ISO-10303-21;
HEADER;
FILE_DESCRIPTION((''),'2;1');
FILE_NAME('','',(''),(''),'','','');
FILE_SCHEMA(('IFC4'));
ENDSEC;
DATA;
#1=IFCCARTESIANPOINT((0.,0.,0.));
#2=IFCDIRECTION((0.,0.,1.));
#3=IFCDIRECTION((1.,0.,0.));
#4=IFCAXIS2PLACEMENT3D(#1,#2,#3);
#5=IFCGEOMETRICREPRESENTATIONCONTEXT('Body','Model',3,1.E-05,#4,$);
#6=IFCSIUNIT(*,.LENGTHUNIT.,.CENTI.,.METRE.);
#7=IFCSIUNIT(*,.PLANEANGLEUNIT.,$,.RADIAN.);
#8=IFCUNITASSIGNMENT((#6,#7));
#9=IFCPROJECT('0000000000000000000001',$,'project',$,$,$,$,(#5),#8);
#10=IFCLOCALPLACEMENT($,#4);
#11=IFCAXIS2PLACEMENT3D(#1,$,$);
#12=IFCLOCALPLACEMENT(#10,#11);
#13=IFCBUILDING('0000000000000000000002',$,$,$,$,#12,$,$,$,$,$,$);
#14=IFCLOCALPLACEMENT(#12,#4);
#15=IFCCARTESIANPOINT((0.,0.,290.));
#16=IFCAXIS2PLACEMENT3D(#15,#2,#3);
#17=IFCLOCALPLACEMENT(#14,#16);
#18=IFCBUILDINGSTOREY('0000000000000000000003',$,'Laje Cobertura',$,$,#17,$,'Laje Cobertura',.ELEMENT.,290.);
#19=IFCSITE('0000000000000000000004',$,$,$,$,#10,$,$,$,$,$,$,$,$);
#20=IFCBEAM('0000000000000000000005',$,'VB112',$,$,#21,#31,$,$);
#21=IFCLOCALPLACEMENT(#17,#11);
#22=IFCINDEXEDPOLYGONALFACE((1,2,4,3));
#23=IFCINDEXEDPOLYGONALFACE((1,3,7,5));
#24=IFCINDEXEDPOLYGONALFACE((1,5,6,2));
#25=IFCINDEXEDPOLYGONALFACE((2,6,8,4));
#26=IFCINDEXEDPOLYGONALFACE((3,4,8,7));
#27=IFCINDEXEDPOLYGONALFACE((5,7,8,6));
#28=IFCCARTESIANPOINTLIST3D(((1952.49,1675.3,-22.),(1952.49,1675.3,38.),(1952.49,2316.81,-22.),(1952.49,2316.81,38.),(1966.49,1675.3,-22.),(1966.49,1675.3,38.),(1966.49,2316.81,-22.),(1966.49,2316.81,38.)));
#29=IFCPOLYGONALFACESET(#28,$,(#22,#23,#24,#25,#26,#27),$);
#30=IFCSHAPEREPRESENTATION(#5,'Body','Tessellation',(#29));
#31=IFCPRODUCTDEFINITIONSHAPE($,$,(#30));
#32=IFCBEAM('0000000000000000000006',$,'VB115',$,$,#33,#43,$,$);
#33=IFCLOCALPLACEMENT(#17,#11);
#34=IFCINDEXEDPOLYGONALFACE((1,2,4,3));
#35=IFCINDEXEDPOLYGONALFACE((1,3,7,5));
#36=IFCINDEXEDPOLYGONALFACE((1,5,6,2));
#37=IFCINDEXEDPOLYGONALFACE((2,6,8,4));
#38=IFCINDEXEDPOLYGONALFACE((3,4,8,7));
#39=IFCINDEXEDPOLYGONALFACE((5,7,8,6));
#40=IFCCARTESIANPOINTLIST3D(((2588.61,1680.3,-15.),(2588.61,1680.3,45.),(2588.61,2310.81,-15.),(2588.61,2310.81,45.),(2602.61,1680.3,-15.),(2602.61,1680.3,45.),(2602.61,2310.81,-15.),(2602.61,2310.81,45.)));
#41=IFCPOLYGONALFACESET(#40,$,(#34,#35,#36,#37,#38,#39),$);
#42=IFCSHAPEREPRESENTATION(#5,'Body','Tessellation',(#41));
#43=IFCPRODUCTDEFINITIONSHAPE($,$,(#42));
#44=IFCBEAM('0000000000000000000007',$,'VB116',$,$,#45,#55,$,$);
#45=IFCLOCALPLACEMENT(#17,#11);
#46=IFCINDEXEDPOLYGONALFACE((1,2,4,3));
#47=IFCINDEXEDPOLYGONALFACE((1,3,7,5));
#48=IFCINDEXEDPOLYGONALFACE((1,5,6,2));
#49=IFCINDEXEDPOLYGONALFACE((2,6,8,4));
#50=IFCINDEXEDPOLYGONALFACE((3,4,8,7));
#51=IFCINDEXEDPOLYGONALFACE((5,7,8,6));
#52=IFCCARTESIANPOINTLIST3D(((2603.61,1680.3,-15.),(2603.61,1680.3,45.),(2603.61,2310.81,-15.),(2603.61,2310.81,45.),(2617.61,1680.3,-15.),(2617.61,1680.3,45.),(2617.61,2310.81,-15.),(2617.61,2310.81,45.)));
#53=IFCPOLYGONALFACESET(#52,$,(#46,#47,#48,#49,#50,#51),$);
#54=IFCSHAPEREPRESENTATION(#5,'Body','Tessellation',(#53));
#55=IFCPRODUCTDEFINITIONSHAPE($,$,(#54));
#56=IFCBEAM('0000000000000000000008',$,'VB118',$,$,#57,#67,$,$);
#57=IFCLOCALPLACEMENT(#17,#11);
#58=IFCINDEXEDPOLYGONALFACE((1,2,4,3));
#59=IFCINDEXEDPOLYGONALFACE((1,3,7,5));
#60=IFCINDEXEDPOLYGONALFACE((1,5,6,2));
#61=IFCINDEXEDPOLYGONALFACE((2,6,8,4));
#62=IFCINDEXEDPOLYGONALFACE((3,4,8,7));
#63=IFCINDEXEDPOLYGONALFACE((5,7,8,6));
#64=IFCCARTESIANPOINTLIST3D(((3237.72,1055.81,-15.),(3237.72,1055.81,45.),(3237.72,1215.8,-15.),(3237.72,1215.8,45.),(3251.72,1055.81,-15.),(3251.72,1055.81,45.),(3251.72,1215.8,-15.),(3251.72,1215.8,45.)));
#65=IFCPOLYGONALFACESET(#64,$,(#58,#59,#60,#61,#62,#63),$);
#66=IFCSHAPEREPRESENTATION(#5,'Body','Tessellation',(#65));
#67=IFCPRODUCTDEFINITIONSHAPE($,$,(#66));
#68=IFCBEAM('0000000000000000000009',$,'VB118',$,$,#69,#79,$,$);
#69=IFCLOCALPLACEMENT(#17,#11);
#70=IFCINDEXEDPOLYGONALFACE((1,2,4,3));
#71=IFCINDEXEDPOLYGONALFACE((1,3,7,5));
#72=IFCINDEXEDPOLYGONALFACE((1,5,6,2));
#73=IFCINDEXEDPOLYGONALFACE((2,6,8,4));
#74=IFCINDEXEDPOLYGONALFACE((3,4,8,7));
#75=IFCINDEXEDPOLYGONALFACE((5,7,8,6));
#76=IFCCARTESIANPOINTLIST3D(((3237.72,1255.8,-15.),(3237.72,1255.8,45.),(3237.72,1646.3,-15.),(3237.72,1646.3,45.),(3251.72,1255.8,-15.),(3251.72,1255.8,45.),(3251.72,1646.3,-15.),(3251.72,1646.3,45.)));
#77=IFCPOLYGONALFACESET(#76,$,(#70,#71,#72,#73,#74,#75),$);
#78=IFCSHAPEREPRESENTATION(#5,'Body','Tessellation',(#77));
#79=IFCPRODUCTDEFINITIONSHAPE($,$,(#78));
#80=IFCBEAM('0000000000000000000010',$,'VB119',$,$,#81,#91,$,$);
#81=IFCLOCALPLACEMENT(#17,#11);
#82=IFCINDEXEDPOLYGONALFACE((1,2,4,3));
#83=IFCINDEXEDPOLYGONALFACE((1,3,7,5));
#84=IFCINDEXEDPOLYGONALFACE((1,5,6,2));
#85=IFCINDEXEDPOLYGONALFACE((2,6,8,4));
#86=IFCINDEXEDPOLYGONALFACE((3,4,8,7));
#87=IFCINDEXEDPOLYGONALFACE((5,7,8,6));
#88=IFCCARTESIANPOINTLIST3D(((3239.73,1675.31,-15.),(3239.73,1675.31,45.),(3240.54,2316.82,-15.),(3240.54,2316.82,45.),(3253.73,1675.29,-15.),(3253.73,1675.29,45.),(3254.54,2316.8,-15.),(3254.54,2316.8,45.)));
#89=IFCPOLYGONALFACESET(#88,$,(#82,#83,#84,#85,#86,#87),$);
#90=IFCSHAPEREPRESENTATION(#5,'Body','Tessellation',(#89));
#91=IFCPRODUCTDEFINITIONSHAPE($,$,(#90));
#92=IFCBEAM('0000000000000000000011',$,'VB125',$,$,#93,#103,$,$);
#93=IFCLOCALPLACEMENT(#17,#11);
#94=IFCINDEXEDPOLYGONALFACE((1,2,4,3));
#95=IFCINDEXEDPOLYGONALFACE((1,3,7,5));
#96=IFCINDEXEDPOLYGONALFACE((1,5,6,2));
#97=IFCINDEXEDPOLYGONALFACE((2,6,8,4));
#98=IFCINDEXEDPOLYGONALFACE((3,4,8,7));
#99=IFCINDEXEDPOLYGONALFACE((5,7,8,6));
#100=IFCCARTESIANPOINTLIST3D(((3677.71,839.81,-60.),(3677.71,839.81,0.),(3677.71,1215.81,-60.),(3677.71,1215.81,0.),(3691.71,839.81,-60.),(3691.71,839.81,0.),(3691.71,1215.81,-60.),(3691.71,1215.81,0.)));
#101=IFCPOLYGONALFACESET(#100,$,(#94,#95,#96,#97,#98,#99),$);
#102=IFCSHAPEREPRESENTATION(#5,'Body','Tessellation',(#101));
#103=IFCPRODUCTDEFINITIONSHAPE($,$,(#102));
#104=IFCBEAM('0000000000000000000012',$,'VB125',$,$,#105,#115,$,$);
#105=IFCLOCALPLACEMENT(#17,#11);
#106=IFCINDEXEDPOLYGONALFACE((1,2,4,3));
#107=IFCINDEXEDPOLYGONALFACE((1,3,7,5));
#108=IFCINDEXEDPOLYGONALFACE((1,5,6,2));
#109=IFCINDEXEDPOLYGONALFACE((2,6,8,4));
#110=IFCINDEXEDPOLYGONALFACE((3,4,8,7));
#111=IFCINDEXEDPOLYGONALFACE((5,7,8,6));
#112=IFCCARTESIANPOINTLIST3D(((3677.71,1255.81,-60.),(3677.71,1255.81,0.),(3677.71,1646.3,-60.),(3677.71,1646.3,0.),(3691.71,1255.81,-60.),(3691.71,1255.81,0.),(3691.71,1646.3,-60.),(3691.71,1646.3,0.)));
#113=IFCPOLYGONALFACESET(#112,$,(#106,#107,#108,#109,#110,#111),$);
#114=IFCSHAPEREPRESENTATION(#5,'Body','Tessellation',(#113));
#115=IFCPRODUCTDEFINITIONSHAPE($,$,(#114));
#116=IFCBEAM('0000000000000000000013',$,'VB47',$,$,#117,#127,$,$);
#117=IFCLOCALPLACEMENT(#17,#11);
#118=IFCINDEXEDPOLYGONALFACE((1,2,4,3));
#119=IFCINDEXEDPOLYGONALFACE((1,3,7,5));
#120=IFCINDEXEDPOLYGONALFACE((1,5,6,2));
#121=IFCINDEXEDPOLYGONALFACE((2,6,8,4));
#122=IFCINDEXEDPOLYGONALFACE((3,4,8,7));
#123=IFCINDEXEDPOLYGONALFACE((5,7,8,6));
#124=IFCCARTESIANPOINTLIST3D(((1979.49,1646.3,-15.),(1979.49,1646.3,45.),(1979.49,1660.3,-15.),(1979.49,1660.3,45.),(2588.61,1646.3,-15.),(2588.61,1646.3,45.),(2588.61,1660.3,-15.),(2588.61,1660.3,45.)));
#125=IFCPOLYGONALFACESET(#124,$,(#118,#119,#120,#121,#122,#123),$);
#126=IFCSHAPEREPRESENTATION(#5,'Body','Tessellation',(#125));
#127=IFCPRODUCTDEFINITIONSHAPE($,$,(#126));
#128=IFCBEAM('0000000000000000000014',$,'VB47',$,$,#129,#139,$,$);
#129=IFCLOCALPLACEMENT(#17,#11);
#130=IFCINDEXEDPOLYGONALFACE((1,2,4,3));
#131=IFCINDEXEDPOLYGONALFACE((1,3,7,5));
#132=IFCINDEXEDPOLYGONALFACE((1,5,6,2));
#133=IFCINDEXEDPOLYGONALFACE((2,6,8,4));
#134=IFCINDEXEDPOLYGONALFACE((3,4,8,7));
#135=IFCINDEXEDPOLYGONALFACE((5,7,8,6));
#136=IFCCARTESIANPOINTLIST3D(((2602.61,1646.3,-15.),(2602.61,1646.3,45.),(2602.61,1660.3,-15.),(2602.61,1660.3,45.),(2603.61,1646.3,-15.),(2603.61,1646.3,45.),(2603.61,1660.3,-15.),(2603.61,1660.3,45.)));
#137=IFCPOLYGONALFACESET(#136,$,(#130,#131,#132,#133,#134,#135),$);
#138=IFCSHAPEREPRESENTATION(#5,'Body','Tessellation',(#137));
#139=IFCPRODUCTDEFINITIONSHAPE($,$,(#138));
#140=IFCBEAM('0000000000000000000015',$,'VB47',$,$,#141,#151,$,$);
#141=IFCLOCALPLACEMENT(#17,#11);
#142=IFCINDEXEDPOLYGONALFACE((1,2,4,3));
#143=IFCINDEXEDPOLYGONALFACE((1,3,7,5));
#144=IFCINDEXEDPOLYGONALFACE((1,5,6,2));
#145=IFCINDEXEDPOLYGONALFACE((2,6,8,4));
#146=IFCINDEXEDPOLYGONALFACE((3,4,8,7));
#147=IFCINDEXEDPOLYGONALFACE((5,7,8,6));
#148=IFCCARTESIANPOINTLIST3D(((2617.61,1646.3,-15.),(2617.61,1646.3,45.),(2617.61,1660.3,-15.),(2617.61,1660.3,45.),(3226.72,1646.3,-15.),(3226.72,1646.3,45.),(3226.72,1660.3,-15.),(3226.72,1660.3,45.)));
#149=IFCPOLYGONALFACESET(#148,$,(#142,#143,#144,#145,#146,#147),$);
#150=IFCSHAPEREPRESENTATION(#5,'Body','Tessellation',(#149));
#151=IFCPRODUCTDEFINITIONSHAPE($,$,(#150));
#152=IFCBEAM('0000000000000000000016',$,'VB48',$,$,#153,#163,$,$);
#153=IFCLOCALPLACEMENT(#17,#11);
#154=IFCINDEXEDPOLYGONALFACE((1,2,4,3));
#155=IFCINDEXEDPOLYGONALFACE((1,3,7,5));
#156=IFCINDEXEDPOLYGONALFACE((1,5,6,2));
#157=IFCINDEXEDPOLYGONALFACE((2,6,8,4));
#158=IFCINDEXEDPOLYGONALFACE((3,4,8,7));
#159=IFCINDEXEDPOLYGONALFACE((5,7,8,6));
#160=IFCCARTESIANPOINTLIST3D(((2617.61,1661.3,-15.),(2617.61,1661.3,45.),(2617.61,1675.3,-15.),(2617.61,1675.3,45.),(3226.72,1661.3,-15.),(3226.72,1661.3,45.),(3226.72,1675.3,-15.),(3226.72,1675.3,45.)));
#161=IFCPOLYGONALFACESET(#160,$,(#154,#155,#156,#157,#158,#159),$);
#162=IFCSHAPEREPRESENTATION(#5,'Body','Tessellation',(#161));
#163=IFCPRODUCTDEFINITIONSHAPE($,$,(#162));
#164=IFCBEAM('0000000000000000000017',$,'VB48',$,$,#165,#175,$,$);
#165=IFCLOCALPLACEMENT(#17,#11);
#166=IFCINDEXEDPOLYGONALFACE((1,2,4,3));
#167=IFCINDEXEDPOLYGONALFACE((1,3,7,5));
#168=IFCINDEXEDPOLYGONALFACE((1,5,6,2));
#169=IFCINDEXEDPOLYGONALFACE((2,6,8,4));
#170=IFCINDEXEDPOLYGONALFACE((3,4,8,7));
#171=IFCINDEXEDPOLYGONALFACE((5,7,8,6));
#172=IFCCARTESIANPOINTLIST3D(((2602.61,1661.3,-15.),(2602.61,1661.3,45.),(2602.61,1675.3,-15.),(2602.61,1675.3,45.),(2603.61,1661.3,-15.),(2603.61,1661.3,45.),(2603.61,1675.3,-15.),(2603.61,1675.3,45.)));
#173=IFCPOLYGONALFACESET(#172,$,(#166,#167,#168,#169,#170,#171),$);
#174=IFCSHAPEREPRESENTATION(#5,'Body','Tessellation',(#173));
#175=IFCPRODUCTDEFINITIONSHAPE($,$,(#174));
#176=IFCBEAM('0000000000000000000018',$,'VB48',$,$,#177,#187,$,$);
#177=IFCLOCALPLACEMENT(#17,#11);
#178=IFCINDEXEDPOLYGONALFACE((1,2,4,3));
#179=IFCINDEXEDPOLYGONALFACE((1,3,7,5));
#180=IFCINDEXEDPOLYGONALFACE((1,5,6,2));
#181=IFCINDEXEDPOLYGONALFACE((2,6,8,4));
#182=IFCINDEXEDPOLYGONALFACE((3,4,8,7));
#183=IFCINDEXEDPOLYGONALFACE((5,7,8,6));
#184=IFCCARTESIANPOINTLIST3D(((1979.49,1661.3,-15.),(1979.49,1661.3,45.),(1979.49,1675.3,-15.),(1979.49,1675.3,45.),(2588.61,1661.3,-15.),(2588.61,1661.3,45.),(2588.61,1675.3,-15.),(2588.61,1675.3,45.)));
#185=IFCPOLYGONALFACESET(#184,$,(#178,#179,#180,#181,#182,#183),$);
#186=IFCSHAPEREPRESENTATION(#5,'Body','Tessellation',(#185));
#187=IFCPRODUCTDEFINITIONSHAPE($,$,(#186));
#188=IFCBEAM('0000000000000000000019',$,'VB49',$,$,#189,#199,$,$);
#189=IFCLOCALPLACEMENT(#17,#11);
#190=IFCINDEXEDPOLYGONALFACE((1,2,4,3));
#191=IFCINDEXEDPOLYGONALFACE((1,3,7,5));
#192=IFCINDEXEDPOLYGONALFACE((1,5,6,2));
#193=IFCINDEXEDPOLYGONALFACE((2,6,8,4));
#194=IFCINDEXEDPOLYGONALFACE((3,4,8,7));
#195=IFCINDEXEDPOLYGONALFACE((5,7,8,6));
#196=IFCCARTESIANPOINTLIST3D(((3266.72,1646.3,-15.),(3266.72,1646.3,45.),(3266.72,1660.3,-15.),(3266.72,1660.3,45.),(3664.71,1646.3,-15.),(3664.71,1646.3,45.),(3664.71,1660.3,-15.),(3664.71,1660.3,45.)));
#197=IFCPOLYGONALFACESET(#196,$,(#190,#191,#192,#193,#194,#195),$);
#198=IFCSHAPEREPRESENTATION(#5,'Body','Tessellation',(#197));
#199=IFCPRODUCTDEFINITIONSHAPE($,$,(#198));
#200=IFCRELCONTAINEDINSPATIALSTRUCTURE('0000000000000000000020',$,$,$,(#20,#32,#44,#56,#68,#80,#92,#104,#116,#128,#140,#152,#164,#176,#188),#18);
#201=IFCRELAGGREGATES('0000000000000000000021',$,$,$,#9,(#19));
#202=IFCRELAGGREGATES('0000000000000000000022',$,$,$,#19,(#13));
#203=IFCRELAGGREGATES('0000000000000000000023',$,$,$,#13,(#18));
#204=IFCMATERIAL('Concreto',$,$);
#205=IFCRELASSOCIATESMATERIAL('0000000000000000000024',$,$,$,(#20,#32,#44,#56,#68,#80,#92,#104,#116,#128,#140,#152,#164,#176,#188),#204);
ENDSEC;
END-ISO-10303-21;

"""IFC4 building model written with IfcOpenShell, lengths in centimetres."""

from ifc_helpers import new_model, si_unit, frame, origin, origin_with_axes, origin_2d_with_axis, place, context, project, spatial, rectangle, extrude, material, element, save


model = new_model("IFC4")

# Units and contexts
model_context = context("Model", 3, precision=1e-05, world=origin_with_axes(), identifier="Body")
ifc_project = project(units=[si_unit("LENGTHUNIT", "METRE", prefix="CENTI"), si_unit("PLANEANGLEUNIT", "RADIAN")], contexts=[model_context])

# Site, building, storey
site_placement = place(None, origin_with_axes())
site = spatial("IfcSite", under=ifc_project, at=site_placement)
building_placement = place(site_placement, origin())
building = spatial("IfcBuilding", under=site, at=building_placement)
placement = place(building_placement, origin_with_axes())
storey_placement = place(placement, frame((0.0, 0.0, 290.0), z_axis=(0.0, 0.0, 1.0), x_axis=(1.0, 0.0, 0.0)))
storey = spatial("IfcBuildingStorey", under=building, at=storey_placement, Name="Laje Cobertura", LongName="Laje Cobertura", CompositionType="ELEMENT", Elevation=290.0)

# Shared definitions
ifc_material = material(Name="Concreto")

# Beams
beam_1_placement = place(storey_placement, frame((1959.49, 1996.06, 38.0), z_axis=(0.0, 0.0, 1.0), x_axis=(1.0, 0.0, 0.0)))
element("IfcBeam", 1, at=beam_1_placement, inside=storey, material=ifc_material, Name="VB112", context=model_context, shape_type="SolidModel", body=[
    extrude(rectangle(XDim=14.0, YDim=60.0, at=origin_2d_with_axis()), frame((0.0, -320.75, -30.0), z_axis=(0.0, 1.0, 0.0), x_axis=(1.0, 0.0, 0.0)), (0.0, 0.0, 1.0), 641.51),
])
for number, where, z_axis, x_axis, name in (
    (2, (2595.61, 1995.56, 45.0), (0.0, 0.0, 1.0), (1.0, 0.0, 0.0), "VB115"),
    (3, (2610.61, 1995.56, 45.0), (0.0, 0.0, 1.0), (1.0, 0.0, 0.0), "VB116"),
):
    element("IfcBeam", number, at=place(storey_placement, frame(where, z_axis=z_axis, x_axis=x_axis)), inside=storey, material=ifc_material, Name=name, context=model_context, shape_type="SolidModel", body=[
        extrude(rectangle(XDim=14.0, YDim=60.0, at=origin_2d_with_axis()), frame((0.0, -315.25, -30.0), z_axis=(0.0, 1.0, 0.0), x_axis=(1.0, 0.0, 0.0)), (0.0, 0.0, 1.0), 630.51),
    ])
beam_2_placement = place(storey_placement, frame((3244.72, 1135.81, 45.0), z_axis=(0.0, 0.0, 1.0), x_axis=(1.0, 0.0, 0.0)))
element("IfcBeam", 4, at=beam_2_placement, inside=storey, material=ifc_material, Name="VB118", context=model_context, shape_type="SolidModel", body=[
    extrude(rectangle(XDim=14.0, YDim=60.0, at=origin_2d_with_axis()), frame((0.0, -80.0, -30.0), z_axis=(0.0, 1.0, 0.0), x_axis=(1.0, 0.0, 0.0)), (0.0, 0.0, 1.0), 159.99),
])
beam_3_placement = place(storey_placement, frame((3244.72, 1451.05, 45.0), z_axis=(0.0, 0.0, 1.0), x_axis=(1.0, 0.0, 0.0)))
element("IfcBeam", 5, at=beam_3_placement, inside=storey, material=ifc_material, Name="VB118", context=model_context, shape_type="SolidModel", body=[
    extrude(rectangle(XDim=14.0, YDim=60.0, at=origin_2d_with_axis()), frame((0.0, -195.25, -30.0), z_axis=(0.0, 1.0, 0.0), x_axis=(1.0, 0.0, 0.0)), (0.0, 0.0, 1.0), 390.5),
])
beam_4_placement = place(storey_placement, frame((3247.14, 1996.06, 45.0), z_axis=(0.0, 0.0, 1.0), x_axis=(1.0, 0.0, 0.0)))
element("IfcBeam", 6, at=beam_4_placement, inside=storey, material=ifc_material, Name="VB119", context=model_context, shape_type="SolidModel", body=[
    extrude(rectangle(XDim=14.0, YDim=60.0, at=origin_2d_with_axis()), frame((-0.41, -320.75, -30.0), z_axis=(0.001263, 1.0, 0.0), x_axis=(1.0, -0.001263, 0.0)), (0.0, 0.0, 1.0), 641.51),
])
beam_5_placement = place(storey_placement, frame((3684.71, 1027.81, 0.0), z_axis=(0.0, 0.0, 1.0), x_axis=(1.0, 0.0, 0.0)))
element("IfcBeam", 7, at=beam_5_placement, inside=storey, material=ifc_material, Name="VB125", context=model_context, shape_type="SolidModel", body=[
    extrude(rectangle(XDim=14.0, YDim=60.0, at=origin_2d_with_axis()), frame((0.0, -188.0, -30.0), z_axis=(0.0, 1.0, 0.0), x_axis=(1.0, 0.0, 0.0)), (0.0, 0.0, 1.0), 376.0),
])
beam_6_placement = place(storey_placement, frame((3684.71, 1451.06, 0.0), z_axis=(0.0, 0.0, 1.0), x_axis=(1.0, 0.0, 0.0)))
element("IfcBeam", 8, at=beam_6_placement, inside=storey, material=ifc_material, Name="VB125", context=model_context, shape_type="SolidModel", body=[
    extrude(rectangle(XDim=14.0, YDim=60.0, at=origin_2d_with_axis()), frame((0.0, -195.25, -30.0), z_axis=(0.0, 1.0, 0.0), x_axis=(1.0, 0.0, 0.0)), (0.0, 0.0, 1.0), 390.49),
])
beam_7_placement = place(storey_placement, frame((2284.05, 1653.3, 45.0), z_axis=(0.0, 0.0, 1.0), x_axis=(1.0, 0.0, 0.0)))
element("IfcBeam", 9, at=beam_7_placement, inside=storey, material=ifc_material, Name="VB47", context=model_context, shape_type="SolidModel", body=[
    extrude(rectangle(XDim=14.0, YDim=60.0, at=origin_2d_with_axis()), frame((-304.56, 0.0, -30.0), z_axis=(1.0, 0.0, 0.0), x_axis=(0.0, 1.0, 0.0)), (0.0, 0.0, 1.0), 609.12),
])
beam_8_placement = place(storey_placement, frame((2603.11, 1653.3, 45.0), z_axis=(0.0, 0.0, 1.0), x_axis=(1.0, 0.0, 0.0)))
element("IfcBeam", 10, at=beam_8_placement, inside=storey, material=ifc_material, Name="VB47", context=model_context, shape_type="SolidModel", body=[
    extrude(rectangle(XDim=14.0, YDim=60.0, at=origin_2d_with_axis()), frame((-0.5, 0.0, -30.0), z_axis=(1.0, 0.0, 0.0), x_axis=(0.0, 1.0, 0.0)), (0.0, 0.0, 1.0), 1.0),
])
for number, where, z_axis, x_axis, name in (
    (11, (2922.16, 1653.3, 45.0), (0.0, 0.0, 1.0), (1.0, 0.0, 0.0), "VB47"),
    (12, (2922.16, 1668.3, 45.0), (0.0, 0.0, 1.0), (1.0, 0.0, 0.0), "VB48"),
):
    element("IfcBeam", number, at=place(storey_placement, frame(where, z_axis=z_axis, x_axis=x_axis)), inside=storey, material=ifc_material, Name=name, context=model_context, shape_type="SolidModel", body=[
        extrude(rectangle(XDim=14.0, YDim=60.0, at=origin_2d_with_axis()), frame((-304.56, 0.0, -30.0), z_axis=(1.0, 0.0, 0.0), x_axis=(0.0, 1.0, 0.0)), (0.0, 0.0, 1.0), 609.11),
    ])
beam_9_placement = place(storey_placement, frame((2603.11, 1668.3, 45.0), z_axis=(0.0, 0.0, 1.0), x_axis=(1.0, 0.0, 0.0)))
element("IfcBeam", 13, at=beam_9_placement, inside=storey, material=ifc_material, Name="VB48", context=model_context, shape_type="SolidModel", body=[
    extrude(rectangle(XDim=14.0, YDim=60.0, at=origin_2d_with_axis()), frame((-0.5, 0.0, -30.0), z_axis=(1.0, 0.0, 0.0), x_axis=(0.0, 1.0, 0.0)), (0.0, 0.0, 1.0), 1.0),
])
beam_10_placement = place(storey_placement, frame((2284.05, 1668.3, 45.0), z_axis=(0.0, 0.0, 1.0), x_axis=(1.0, 0.0, 0.0)))
element("IfcBeam", 14, at=beam_10_placement, inside=storey, material=ifc_material, Name="VB48", context=model_context, shape_type="SolidModel", body=[
    extrude(rectangle(XDim=14.0, YDim=60.0, at=origin_2d_with_axis()), frame((-304.56, 0.0, -30.0), z_axis=(1.0, 0.0, 0.0), x_axis=(0.0, 1.0, 0.0)), (0.0, 0.0, 1.0), 609.12),
])
for number, where, z_axis, x_axis, name in (
    (15, (3465.72, 1653.3, 45.0), (0.0, 0.0, 1.0), (1.0, 0.0, 0.0), "VB49"),
):
    element("IfcBeam", number, at=place(storey_placement, frame(where, z_axis=z_axis, x_axis=x_axis)), inside=storey, material=ifc_material, Name=name, context=model_context, shape_type="SolidModel", body=[
        extrude(rectangle(XDim=14.0, YDim=60.0, at=origin_2d_with_axis()), frame((-199.0, 0.0, -30.0), z_axis=(1.0, 0.0, 0.0), x_axis=(0.0, 1.0, 0.0)), (0.0, 0.0, 1.0), 397.99),
    ])

save(model, "model.ifc")
